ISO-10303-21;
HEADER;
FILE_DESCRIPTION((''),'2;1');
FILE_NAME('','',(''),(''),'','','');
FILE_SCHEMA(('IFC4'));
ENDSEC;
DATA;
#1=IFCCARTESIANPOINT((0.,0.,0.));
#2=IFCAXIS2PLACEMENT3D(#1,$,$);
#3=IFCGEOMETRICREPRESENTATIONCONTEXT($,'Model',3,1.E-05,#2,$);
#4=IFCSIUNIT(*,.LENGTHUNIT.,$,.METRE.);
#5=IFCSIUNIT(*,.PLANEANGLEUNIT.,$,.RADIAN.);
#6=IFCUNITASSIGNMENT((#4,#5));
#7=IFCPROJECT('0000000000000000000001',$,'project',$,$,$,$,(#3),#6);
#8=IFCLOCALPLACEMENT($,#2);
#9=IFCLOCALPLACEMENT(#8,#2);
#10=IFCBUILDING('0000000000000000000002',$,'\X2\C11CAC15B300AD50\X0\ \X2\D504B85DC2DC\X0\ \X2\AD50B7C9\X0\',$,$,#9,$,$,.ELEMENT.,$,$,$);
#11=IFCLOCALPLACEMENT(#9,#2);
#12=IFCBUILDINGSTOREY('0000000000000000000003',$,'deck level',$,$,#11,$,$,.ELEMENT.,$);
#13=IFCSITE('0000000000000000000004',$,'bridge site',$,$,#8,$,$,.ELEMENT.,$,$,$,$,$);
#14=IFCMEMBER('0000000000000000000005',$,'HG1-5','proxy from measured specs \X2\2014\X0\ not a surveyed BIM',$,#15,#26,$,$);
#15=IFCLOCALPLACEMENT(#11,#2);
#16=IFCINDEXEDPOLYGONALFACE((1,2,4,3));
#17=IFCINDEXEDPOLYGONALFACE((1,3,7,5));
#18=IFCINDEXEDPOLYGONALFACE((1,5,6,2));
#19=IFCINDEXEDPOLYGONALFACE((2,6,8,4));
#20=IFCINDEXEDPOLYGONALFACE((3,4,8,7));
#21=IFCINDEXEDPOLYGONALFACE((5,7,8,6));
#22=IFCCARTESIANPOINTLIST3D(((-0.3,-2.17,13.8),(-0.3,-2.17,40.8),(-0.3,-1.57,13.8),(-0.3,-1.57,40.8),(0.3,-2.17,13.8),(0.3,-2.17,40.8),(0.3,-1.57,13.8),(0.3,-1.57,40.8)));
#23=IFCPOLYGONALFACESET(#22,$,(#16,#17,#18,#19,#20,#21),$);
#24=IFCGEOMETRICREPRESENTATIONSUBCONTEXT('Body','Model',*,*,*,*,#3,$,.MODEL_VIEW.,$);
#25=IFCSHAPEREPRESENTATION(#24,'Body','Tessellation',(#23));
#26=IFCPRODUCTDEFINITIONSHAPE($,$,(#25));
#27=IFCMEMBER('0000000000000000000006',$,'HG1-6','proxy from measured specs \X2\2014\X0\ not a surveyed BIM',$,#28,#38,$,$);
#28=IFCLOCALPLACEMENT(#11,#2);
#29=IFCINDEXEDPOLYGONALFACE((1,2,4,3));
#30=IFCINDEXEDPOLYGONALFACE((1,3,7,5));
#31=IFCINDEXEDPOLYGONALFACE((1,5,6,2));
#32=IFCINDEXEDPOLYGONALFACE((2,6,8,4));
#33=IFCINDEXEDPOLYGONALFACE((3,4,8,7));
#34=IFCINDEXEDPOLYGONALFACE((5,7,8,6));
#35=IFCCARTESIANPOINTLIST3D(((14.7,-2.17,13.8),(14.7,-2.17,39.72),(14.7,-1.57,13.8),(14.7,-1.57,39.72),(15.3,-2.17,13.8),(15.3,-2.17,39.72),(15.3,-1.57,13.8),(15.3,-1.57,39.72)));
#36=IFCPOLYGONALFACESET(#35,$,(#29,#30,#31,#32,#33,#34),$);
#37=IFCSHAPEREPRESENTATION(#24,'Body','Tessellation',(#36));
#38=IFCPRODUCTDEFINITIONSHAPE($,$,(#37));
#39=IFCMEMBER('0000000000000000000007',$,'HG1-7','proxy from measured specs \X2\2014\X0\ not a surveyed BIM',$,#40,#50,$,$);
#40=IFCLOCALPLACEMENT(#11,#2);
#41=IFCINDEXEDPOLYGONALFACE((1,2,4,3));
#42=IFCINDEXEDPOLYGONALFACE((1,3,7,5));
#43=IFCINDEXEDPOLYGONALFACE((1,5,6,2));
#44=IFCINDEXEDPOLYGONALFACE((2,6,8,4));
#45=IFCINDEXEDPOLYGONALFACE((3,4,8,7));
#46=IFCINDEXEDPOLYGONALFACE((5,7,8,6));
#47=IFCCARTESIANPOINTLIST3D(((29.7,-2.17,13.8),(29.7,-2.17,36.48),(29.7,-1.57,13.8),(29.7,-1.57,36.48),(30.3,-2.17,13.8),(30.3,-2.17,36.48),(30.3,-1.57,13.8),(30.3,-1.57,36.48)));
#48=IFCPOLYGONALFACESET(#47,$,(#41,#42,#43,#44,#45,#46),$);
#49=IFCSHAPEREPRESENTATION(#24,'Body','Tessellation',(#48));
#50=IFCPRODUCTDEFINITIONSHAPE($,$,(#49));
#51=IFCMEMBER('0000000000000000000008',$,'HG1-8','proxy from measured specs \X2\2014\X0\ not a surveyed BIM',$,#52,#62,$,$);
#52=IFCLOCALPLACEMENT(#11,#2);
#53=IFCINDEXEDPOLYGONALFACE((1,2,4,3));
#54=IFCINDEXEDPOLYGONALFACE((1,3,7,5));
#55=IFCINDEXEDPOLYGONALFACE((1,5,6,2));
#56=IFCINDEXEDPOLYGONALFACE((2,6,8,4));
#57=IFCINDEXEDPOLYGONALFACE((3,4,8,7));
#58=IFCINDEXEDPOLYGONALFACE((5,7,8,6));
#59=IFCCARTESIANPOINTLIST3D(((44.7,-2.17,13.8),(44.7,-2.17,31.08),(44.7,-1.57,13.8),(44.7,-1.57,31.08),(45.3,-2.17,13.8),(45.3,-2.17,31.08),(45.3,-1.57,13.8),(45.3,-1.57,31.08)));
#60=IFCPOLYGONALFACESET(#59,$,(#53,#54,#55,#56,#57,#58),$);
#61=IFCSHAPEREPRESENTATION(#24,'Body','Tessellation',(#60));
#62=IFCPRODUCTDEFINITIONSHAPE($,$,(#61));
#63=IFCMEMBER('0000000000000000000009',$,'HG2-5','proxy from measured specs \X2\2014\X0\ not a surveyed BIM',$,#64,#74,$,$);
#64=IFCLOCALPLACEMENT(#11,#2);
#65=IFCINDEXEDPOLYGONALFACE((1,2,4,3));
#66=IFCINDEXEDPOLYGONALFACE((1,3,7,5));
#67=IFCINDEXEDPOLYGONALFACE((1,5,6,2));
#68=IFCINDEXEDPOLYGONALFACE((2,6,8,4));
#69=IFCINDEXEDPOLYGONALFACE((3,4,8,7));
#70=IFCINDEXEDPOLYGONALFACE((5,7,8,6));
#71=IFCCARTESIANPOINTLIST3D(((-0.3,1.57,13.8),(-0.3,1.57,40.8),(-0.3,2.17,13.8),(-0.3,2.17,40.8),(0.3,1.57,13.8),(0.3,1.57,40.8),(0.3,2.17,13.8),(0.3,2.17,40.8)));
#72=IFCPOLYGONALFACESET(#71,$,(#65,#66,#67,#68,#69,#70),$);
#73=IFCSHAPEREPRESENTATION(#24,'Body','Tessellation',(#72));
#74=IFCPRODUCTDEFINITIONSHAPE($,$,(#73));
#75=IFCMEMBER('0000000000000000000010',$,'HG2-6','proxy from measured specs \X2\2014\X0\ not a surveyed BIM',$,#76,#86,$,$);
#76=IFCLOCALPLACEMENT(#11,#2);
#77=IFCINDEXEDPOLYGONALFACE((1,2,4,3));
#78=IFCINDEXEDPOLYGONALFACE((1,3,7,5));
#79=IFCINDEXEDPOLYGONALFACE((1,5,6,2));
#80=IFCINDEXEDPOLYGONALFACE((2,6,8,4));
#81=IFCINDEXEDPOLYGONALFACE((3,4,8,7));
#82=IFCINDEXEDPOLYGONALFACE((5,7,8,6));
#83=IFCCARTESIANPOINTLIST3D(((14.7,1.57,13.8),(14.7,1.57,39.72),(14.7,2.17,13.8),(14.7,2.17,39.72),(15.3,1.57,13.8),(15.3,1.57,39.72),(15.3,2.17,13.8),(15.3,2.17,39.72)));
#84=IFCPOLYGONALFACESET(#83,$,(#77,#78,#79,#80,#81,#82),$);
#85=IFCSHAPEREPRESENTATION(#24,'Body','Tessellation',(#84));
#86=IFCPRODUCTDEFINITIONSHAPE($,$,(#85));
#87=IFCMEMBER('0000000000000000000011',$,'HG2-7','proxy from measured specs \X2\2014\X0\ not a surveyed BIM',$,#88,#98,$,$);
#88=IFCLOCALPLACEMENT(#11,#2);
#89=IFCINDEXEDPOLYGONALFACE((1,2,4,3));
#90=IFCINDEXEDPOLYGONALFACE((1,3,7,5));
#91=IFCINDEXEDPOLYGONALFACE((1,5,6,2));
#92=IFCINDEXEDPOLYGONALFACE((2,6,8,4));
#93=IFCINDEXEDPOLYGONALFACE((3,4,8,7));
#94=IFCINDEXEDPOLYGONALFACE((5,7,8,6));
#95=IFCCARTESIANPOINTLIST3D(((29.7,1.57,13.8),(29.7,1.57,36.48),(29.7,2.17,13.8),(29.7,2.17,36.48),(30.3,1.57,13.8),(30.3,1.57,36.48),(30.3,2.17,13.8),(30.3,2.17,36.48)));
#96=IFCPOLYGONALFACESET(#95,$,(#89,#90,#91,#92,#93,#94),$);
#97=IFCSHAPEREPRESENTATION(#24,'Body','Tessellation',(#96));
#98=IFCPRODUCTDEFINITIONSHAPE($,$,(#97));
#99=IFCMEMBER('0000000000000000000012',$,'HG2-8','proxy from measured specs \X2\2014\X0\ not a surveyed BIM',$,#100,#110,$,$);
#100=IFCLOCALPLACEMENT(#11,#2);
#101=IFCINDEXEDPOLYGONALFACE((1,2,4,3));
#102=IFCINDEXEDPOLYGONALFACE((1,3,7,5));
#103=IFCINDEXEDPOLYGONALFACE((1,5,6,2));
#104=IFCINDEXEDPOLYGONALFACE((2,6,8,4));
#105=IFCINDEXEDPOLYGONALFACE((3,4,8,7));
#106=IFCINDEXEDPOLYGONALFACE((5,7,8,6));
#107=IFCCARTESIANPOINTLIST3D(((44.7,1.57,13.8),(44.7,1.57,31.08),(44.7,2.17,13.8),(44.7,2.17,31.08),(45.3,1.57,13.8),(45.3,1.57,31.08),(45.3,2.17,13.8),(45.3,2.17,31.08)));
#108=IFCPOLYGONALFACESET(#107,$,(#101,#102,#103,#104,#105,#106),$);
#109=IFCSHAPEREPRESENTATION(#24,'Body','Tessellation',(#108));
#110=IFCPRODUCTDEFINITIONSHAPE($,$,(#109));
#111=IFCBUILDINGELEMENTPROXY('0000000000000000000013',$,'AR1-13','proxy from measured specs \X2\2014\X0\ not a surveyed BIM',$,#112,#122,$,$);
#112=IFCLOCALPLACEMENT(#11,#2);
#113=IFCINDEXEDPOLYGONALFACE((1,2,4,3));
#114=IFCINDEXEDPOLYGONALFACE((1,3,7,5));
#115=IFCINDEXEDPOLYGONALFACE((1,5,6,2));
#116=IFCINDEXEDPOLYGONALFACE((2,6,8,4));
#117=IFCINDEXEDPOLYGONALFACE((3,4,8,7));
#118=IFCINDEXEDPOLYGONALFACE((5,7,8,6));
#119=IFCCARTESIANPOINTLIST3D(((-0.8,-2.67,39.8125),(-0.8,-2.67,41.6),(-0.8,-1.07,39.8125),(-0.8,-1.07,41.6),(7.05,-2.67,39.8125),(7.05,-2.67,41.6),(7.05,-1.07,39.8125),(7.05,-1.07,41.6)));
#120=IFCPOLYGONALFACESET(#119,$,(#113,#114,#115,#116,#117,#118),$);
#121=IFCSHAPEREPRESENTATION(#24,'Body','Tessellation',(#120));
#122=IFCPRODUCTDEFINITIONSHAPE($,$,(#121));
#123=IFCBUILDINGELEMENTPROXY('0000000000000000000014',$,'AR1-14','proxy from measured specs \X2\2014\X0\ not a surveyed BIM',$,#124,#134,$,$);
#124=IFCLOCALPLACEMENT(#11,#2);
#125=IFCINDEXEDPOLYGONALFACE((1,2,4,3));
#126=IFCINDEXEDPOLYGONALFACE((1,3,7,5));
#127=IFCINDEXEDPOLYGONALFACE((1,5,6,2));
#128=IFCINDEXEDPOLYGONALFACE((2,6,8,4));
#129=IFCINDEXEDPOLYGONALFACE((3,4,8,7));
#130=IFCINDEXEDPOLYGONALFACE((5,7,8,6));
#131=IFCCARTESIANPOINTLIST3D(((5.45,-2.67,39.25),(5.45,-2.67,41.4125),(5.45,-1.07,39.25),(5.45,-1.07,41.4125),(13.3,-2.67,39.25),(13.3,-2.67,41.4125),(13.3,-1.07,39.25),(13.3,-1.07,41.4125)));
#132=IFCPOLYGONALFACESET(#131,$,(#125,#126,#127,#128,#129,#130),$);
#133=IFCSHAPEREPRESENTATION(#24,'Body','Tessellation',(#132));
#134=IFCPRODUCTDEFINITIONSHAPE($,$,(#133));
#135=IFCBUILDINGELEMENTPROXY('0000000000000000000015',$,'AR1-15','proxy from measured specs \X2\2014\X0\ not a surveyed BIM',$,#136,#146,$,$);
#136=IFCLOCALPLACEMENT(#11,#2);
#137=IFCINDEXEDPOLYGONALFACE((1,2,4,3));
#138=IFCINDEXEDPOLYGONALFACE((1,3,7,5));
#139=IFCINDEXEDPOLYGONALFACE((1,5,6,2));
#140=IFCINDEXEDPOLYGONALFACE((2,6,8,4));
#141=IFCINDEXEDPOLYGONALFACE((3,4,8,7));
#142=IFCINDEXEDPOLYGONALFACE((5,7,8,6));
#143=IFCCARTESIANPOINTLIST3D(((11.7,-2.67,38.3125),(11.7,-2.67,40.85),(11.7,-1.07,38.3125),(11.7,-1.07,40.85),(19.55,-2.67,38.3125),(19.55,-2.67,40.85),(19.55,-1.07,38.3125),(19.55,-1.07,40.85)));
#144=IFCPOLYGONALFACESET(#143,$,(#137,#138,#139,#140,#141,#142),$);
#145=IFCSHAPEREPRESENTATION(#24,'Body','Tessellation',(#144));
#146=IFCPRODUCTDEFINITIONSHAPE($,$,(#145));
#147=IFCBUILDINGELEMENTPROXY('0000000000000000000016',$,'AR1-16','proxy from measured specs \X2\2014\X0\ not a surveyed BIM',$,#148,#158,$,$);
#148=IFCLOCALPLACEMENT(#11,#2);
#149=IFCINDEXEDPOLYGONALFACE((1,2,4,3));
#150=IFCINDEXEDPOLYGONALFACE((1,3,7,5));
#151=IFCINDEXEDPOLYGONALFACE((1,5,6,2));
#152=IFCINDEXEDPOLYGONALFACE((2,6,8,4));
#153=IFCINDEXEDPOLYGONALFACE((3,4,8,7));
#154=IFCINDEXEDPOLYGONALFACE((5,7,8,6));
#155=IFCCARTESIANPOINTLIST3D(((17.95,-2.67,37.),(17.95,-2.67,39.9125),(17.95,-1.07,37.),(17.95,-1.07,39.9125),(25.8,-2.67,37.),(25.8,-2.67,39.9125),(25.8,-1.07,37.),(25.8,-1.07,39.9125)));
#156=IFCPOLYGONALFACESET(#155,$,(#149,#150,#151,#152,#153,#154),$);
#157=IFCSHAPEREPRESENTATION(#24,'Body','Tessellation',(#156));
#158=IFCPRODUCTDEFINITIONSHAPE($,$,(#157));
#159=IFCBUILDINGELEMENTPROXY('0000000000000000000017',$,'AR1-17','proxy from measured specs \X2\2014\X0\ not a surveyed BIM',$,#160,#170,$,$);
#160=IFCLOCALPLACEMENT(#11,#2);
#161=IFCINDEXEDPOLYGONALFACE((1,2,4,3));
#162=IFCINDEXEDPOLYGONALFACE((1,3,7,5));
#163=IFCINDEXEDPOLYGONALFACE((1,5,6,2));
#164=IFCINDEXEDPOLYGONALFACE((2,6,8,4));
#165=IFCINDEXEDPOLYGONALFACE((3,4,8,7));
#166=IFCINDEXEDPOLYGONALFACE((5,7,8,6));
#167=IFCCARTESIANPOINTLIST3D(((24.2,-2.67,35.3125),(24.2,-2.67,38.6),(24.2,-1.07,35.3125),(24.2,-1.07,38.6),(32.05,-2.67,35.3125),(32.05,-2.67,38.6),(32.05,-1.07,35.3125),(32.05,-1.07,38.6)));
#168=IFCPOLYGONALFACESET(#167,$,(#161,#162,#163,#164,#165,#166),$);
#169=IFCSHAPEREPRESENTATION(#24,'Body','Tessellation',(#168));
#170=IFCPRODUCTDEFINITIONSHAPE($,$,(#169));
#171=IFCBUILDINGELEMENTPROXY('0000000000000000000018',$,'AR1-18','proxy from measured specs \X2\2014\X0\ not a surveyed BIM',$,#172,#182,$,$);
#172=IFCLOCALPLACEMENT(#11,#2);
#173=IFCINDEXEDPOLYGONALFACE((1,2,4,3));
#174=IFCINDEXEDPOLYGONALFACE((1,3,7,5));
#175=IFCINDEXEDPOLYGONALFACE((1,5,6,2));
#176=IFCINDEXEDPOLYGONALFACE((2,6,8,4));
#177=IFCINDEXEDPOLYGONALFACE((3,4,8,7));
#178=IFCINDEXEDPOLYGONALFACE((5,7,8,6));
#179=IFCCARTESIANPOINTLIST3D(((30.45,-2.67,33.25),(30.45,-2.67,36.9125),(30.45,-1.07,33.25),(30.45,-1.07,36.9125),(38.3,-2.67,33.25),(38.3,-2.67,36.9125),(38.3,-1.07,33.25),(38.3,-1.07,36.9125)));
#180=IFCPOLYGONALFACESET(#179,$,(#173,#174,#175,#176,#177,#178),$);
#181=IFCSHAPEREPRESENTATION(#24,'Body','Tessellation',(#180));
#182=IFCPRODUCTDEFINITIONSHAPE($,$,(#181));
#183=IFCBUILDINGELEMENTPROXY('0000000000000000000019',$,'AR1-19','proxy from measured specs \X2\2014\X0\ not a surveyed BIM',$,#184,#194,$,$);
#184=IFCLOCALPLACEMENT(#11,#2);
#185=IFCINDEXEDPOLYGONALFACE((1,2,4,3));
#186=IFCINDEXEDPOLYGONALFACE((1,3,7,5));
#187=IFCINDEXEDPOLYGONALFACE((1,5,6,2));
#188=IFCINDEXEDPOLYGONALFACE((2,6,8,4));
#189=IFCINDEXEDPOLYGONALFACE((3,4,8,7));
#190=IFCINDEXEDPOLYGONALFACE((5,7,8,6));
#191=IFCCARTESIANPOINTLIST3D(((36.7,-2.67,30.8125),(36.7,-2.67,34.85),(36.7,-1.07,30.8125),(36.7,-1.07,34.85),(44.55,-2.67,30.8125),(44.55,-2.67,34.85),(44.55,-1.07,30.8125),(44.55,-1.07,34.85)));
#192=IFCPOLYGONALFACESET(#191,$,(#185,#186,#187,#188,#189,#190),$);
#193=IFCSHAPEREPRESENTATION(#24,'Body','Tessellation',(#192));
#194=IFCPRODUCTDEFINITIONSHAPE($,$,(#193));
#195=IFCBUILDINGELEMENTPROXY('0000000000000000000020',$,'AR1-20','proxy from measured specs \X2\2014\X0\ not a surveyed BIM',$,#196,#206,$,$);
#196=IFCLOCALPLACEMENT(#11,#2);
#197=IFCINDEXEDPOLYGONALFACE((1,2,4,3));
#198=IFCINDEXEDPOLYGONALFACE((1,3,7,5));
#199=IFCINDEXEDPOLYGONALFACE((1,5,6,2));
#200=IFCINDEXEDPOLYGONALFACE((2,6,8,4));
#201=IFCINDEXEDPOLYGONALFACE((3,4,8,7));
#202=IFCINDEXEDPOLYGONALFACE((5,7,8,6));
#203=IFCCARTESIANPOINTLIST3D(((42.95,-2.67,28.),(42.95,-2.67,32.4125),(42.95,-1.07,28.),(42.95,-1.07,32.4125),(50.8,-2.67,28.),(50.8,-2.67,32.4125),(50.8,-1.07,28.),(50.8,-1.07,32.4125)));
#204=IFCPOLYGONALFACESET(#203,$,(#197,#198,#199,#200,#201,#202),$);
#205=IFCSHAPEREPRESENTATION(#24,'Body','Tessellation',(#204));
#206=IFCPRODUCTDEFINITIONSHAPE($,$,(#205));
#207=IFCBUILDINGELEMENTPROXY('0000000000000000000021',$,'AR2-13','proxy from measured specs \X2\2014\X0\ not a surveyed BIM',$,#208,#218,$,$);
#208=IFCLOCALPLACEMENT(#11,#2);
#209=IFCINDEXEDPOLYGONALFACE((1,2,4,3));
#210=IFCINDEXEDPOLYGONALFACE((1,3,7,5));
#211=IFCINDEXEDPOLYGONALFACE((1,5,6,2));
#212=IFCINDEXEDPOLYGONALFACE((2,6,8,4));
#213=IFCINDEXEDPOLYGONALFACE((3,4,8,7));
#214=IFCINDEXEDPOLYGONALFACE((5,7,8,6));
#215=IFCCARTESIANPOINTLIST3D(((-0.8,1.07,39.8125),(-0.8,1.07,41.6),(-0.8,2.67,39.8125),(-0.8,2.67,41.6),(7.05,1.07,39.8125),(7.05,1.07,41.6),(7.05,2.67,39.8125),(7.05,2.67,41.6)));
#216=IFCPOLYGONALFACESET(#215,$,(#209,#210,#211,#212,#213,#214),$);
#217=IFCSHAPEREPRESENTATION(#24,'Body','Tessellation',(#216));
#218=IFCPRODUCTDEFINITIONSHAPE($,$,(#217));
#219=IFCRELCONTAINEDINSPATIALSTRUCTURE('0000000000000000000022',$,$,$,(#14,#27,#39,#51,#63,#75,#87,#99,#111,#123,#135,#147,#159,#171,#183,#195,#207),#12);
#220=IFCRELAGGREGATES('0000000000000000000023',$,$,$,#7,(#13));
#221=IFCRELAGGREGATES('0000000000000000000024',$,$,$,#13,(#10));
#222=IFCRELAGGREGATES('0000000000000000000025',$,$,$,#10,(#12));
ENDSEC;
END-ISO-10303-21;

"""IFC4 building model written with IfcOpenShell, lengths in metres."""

from ifc_helpers import new_model, si_unit, frame, origin, origin_2d, place, context, subcontext, project, spatial, rectangle, extrude, element, save


model = new_model("IFC4")

# Units and contexts
model_context = context("Model", 3, precision=1e-05, world=origin())
body_context = subcontext(model_context, "Body", "Model", "MODEL_VIEW")
ifc_project = project(units=[si_unit("LENGTHUNIT", "METRE"), si_unit("PLANEANGLEUNIT", "RADIAN")], contexts=[model_context])

# Site, building, storey
site_placement = place(None, origin())
site = spatial("IfcSite", under=ifc_project, at=site_placement, Name="bridge site", CompositionType="ELEMENT")
building_placement = place(site_placement, origin())
building = spatial("IfcBuilding", under=site, at=building_placement, Name="서강대교 프록시 교량", CompositionType="ELEMENT")
storey_placement = place(building_placement, origin())
storey = spatial("IfcBuildingStorey", under=building, at=storey_placement, Name="deck level", CompositionType="ELEMENT")

# Members
member_1_placement = place(storey_placement, frame((0.0, -1.87, 13.8)))
element("IfcMember", 1, at=member_1_placement, inside=storey, Name="HG1-5", Description="proxy from measured specs — not a surveyed BIM", context=body_context, shape_type="SweptSolid", body=[
    extrude(rectangle(XDim=0.6, YDim=0.6, at=origin_2d()), origin(), (0.0, 0.0, 1.0), 27.0),
])
member_2_placement = place(storey_placement, frame((15.0, -1.87, 13.8)))
element("IfcMember", 2, at=member_2_placement, inside=storey, Name="HG1-6", Description="proxy from measured specs — not a surveyed BIM", context=body_context, shape_type="SweptSolid", body=[
    extrude(rectangle(XDim=0.6, YDim=0.6, at=origin_2d()), origin(), (0.0, 0.0, 1.0), 25.92),
])
member_3_placement = place(storey_placement, frame((30.0, -1.87, 13.8)))
element("IfcMember", 3, at=member_3_placement, inside=storey, Name="HG1-7", Description="proxy from measured specs — not a surveyed BIM", context=body_context, shape_type="SweptSolid", body=[
    extrude(rectangle(XDim=0.6, YDim=0.6, at=origin_2d()), origin(), (0.0, 0.0, 1.0), 22.68),
])
member_4_placement = place(storey_placement, frame((45.0, -1.87, 13.8)))
element("IfcMember", 4, at=member_4_placement, inside=storey, Name="HG1-8", Description="proxy from measured specs — not a surveyed BIM", context=body_context, shape_type="SweptSolid", body=[
    extrude(rectangle(XDim=0.6, YDim=0.6, at=origin_2d()), origin(), (0.0, 0.0, 1.0), 17.28),
])
member_5_placement = place(storey_placement, frame((0.0, 1.87, 13.8)))
element("IfcMember", 5, at=member_5_placement, inside=storey, Name="HG2-5", Description="proxy from measured specs — not a surveyed BIM", context=body_context, shape_type="SweptSolid", body=[
    extrude(rectangle(XDim=0.6, YDim=0.6, at=origin_2d()), origin(), (0.0, 0.0, 1.0), 27.0),
])
member_6_placement = place(storey_placement, frame((15.0, 1.87, 13.8)))
element("IfcMember", 6, at=member_6_placement, inside=storey, Name="HG2-6", Description="proxy from measured specs — not a surveyed BIM", context=body_context, shape_type="SweptSolid", body=[
    extrude(rectangle(XDim=0.6, YDim=0.6, at=origin_2d()), origin(), (0.0, 0.0, 1.0), 25.92),
])
member_7_placement = place(storey_placement, frame((30.0, 1.87, 13.8)))
element("IfcMember", 7, at=member_7_placement, inside=storey, Name="HG2-7", Description="proxy from measured specs — not a surveyed BIM", context=body_context, shape_type="SweptSolid", body=[
    extrude(rectangle(XDim=0.6, YDim=0.6, at=origin_2d()), origin(), (0.0, 0.0, 1.0), 22.68),
])
member_8_placement = place(storey_placement, frame((45.0, 1.87, 13.8)))
element("IfcMember", 8, at=member_8_placement, inside=storey, Name="HG2-8", Description="proxy from measured specs — not a surveyed BIM", context=body_context, shape_type="SweptSolid", body=[
    extrude(rectangle(XDim=0.6, YDim=0.6, at=origin_2d()), origin(), (0.0, 0.0, 1.0), 17.28),
])

# Building element proxies
proxy_1_placement = place(storey_placement, frame((3.125, -1.87, 39.8125)))
element("IfcBuildingElementProxy", 9, at=proxy_1_placement, inside=storey, Name="AR1-13", Description="proxy from measured specs — not a surveyed BIM", context=body_context, shape_type="SweptSolid", body=[
    extrude(rectangle(XDim=7.85, YDim=1.6, at=origin_2d()), origin(), (0.0, 0.0, 1.0), 1.7875),
])
proxy_2_placement = place(storey_placement, frame((9.375, -1.87, 39.25)))
element("IfcBuildingElementProxy", 10, at=proxy_2_placement, inside=storey, Name="AR1-14", Description="proxy from measured specs — not a surveyed BIM", context=body_context, shape_type="SweptSolid", body=[
    extrude(rectangle(XDim=7.85, YDim=1.6, at=origin_2d()), origin(), (0.0, 0.0, 1.0), 2.1625),
])
proxy_3_placement = place(storey_placement, frame((15.625, -1.87, 38.3125)))
element("IfcBuildingElementProxy", 11, at=proxy_3_placement, inside=storey, Name="AR1-15", Description="proxy from measured specs — not a surveyed BIM", context=body_context, shape_type="SweptSolid", body=[
    extrude(rectangle(XDim=7.85, YDim=1.6, at=origin_2d()), origin(), (0.0, 0.0, 1.0), 2.5375),
])
proxy_4_placement = place(storey_placement, frame((21.875, -1.87, 37.0)))
element("IfcBuildingElementProxy", 12, at=proxy_4_placement, inside=storey, Name="AR1-16", Description="proxy from measured specs — not a surveyed BIM", context=body_context, shape_type="SweptSolid", body=[
    extrude(rectangle(XDim=7.85, YDim=1.6, at=origin_2d()), origin(), (0.0, 0.0, 1.0), 2.9125),
])
proxy_5_placement = place(storey_placement, frame((28.125, -1.87, 35.3125)))
element("IfcBuildingElementProxy", 13, at=proxy_5_placement, inside=storey, Name="AR1-17", Description="proxy from measured specs — not a surveyed BIM", context=body_context, shape_type="SweptSolid", body=[
    extrude(rectangle(XDim=7.85, YDim=1.6, at=origin_2d()), origin(), (0.0, 0.0, 1.0), 3.2875),
])
proxy_6_placement = place(storey_placement, frame((34.375, -1.87, 33.25)))
element("IfcBuildingElementProxy", 14, at=proxy_6_placement, inside=storey, Name="AR1-18", Description="proxy from measured specs — not a surveyed BIM", context=body_context, shape_type="SweptSolid", body=[
    extrude(rectangle(XDim=7.85, YDim=1.6, at=origin_2d()), origin(), (0.0, 0.0, 1.0), 3.6625),
])
proxy_7_placement = place(storey_placement, frame((40.625, -1.87, 30.8125)))
element("IfcBuildingElementProxy", 15, at=proxy_7_placement, inside=storey, Name="AR1-19", Description="proxy from measured specs — not a surveyed BIM", context=body_context, shape_type="SweptSolid", body=[
    extrude(rectangle(XDim=7.85, YDim=1.6, at=origin_2d()), origin(), (0.0, 0.0, 1.0), 4.0375),
])
proxy_8_placement = place(storey_placement, frame((46.875, -1.87, 28.0)))
element("IfcBuildingElementProxy", 16, at=proxy_8_placement, inside=storey, Name="AR1-20", Description="proxy from measured specs — not a surveyed BIM", context=body_context, shape_type="SweptSolid", body=[
    extrude(rectangle(XDim=7.85, YDim=1.6, at=origin_2d()), origin(), (0.0, 0.0, 1.0), 4.4125),
])
proxy_9_placement = place(storey_placement, frame((3.125, 1.87, 39.8125)))
element("IfcBuildingElementProxy", 17, at=proxy_9_placement, inside=storey, Name="AR2-13", Description="proxy from measured specs — not a surveyed BIM", context=body_context, shape_type="SweptSolid", body=[
    extrude(rectangle(XDim=7.85, YDim=1.6, at=origin_2d()), origin(), (0.0, 0.0, 1.0), 1.7875),
])

save(model, "model.ifc")
